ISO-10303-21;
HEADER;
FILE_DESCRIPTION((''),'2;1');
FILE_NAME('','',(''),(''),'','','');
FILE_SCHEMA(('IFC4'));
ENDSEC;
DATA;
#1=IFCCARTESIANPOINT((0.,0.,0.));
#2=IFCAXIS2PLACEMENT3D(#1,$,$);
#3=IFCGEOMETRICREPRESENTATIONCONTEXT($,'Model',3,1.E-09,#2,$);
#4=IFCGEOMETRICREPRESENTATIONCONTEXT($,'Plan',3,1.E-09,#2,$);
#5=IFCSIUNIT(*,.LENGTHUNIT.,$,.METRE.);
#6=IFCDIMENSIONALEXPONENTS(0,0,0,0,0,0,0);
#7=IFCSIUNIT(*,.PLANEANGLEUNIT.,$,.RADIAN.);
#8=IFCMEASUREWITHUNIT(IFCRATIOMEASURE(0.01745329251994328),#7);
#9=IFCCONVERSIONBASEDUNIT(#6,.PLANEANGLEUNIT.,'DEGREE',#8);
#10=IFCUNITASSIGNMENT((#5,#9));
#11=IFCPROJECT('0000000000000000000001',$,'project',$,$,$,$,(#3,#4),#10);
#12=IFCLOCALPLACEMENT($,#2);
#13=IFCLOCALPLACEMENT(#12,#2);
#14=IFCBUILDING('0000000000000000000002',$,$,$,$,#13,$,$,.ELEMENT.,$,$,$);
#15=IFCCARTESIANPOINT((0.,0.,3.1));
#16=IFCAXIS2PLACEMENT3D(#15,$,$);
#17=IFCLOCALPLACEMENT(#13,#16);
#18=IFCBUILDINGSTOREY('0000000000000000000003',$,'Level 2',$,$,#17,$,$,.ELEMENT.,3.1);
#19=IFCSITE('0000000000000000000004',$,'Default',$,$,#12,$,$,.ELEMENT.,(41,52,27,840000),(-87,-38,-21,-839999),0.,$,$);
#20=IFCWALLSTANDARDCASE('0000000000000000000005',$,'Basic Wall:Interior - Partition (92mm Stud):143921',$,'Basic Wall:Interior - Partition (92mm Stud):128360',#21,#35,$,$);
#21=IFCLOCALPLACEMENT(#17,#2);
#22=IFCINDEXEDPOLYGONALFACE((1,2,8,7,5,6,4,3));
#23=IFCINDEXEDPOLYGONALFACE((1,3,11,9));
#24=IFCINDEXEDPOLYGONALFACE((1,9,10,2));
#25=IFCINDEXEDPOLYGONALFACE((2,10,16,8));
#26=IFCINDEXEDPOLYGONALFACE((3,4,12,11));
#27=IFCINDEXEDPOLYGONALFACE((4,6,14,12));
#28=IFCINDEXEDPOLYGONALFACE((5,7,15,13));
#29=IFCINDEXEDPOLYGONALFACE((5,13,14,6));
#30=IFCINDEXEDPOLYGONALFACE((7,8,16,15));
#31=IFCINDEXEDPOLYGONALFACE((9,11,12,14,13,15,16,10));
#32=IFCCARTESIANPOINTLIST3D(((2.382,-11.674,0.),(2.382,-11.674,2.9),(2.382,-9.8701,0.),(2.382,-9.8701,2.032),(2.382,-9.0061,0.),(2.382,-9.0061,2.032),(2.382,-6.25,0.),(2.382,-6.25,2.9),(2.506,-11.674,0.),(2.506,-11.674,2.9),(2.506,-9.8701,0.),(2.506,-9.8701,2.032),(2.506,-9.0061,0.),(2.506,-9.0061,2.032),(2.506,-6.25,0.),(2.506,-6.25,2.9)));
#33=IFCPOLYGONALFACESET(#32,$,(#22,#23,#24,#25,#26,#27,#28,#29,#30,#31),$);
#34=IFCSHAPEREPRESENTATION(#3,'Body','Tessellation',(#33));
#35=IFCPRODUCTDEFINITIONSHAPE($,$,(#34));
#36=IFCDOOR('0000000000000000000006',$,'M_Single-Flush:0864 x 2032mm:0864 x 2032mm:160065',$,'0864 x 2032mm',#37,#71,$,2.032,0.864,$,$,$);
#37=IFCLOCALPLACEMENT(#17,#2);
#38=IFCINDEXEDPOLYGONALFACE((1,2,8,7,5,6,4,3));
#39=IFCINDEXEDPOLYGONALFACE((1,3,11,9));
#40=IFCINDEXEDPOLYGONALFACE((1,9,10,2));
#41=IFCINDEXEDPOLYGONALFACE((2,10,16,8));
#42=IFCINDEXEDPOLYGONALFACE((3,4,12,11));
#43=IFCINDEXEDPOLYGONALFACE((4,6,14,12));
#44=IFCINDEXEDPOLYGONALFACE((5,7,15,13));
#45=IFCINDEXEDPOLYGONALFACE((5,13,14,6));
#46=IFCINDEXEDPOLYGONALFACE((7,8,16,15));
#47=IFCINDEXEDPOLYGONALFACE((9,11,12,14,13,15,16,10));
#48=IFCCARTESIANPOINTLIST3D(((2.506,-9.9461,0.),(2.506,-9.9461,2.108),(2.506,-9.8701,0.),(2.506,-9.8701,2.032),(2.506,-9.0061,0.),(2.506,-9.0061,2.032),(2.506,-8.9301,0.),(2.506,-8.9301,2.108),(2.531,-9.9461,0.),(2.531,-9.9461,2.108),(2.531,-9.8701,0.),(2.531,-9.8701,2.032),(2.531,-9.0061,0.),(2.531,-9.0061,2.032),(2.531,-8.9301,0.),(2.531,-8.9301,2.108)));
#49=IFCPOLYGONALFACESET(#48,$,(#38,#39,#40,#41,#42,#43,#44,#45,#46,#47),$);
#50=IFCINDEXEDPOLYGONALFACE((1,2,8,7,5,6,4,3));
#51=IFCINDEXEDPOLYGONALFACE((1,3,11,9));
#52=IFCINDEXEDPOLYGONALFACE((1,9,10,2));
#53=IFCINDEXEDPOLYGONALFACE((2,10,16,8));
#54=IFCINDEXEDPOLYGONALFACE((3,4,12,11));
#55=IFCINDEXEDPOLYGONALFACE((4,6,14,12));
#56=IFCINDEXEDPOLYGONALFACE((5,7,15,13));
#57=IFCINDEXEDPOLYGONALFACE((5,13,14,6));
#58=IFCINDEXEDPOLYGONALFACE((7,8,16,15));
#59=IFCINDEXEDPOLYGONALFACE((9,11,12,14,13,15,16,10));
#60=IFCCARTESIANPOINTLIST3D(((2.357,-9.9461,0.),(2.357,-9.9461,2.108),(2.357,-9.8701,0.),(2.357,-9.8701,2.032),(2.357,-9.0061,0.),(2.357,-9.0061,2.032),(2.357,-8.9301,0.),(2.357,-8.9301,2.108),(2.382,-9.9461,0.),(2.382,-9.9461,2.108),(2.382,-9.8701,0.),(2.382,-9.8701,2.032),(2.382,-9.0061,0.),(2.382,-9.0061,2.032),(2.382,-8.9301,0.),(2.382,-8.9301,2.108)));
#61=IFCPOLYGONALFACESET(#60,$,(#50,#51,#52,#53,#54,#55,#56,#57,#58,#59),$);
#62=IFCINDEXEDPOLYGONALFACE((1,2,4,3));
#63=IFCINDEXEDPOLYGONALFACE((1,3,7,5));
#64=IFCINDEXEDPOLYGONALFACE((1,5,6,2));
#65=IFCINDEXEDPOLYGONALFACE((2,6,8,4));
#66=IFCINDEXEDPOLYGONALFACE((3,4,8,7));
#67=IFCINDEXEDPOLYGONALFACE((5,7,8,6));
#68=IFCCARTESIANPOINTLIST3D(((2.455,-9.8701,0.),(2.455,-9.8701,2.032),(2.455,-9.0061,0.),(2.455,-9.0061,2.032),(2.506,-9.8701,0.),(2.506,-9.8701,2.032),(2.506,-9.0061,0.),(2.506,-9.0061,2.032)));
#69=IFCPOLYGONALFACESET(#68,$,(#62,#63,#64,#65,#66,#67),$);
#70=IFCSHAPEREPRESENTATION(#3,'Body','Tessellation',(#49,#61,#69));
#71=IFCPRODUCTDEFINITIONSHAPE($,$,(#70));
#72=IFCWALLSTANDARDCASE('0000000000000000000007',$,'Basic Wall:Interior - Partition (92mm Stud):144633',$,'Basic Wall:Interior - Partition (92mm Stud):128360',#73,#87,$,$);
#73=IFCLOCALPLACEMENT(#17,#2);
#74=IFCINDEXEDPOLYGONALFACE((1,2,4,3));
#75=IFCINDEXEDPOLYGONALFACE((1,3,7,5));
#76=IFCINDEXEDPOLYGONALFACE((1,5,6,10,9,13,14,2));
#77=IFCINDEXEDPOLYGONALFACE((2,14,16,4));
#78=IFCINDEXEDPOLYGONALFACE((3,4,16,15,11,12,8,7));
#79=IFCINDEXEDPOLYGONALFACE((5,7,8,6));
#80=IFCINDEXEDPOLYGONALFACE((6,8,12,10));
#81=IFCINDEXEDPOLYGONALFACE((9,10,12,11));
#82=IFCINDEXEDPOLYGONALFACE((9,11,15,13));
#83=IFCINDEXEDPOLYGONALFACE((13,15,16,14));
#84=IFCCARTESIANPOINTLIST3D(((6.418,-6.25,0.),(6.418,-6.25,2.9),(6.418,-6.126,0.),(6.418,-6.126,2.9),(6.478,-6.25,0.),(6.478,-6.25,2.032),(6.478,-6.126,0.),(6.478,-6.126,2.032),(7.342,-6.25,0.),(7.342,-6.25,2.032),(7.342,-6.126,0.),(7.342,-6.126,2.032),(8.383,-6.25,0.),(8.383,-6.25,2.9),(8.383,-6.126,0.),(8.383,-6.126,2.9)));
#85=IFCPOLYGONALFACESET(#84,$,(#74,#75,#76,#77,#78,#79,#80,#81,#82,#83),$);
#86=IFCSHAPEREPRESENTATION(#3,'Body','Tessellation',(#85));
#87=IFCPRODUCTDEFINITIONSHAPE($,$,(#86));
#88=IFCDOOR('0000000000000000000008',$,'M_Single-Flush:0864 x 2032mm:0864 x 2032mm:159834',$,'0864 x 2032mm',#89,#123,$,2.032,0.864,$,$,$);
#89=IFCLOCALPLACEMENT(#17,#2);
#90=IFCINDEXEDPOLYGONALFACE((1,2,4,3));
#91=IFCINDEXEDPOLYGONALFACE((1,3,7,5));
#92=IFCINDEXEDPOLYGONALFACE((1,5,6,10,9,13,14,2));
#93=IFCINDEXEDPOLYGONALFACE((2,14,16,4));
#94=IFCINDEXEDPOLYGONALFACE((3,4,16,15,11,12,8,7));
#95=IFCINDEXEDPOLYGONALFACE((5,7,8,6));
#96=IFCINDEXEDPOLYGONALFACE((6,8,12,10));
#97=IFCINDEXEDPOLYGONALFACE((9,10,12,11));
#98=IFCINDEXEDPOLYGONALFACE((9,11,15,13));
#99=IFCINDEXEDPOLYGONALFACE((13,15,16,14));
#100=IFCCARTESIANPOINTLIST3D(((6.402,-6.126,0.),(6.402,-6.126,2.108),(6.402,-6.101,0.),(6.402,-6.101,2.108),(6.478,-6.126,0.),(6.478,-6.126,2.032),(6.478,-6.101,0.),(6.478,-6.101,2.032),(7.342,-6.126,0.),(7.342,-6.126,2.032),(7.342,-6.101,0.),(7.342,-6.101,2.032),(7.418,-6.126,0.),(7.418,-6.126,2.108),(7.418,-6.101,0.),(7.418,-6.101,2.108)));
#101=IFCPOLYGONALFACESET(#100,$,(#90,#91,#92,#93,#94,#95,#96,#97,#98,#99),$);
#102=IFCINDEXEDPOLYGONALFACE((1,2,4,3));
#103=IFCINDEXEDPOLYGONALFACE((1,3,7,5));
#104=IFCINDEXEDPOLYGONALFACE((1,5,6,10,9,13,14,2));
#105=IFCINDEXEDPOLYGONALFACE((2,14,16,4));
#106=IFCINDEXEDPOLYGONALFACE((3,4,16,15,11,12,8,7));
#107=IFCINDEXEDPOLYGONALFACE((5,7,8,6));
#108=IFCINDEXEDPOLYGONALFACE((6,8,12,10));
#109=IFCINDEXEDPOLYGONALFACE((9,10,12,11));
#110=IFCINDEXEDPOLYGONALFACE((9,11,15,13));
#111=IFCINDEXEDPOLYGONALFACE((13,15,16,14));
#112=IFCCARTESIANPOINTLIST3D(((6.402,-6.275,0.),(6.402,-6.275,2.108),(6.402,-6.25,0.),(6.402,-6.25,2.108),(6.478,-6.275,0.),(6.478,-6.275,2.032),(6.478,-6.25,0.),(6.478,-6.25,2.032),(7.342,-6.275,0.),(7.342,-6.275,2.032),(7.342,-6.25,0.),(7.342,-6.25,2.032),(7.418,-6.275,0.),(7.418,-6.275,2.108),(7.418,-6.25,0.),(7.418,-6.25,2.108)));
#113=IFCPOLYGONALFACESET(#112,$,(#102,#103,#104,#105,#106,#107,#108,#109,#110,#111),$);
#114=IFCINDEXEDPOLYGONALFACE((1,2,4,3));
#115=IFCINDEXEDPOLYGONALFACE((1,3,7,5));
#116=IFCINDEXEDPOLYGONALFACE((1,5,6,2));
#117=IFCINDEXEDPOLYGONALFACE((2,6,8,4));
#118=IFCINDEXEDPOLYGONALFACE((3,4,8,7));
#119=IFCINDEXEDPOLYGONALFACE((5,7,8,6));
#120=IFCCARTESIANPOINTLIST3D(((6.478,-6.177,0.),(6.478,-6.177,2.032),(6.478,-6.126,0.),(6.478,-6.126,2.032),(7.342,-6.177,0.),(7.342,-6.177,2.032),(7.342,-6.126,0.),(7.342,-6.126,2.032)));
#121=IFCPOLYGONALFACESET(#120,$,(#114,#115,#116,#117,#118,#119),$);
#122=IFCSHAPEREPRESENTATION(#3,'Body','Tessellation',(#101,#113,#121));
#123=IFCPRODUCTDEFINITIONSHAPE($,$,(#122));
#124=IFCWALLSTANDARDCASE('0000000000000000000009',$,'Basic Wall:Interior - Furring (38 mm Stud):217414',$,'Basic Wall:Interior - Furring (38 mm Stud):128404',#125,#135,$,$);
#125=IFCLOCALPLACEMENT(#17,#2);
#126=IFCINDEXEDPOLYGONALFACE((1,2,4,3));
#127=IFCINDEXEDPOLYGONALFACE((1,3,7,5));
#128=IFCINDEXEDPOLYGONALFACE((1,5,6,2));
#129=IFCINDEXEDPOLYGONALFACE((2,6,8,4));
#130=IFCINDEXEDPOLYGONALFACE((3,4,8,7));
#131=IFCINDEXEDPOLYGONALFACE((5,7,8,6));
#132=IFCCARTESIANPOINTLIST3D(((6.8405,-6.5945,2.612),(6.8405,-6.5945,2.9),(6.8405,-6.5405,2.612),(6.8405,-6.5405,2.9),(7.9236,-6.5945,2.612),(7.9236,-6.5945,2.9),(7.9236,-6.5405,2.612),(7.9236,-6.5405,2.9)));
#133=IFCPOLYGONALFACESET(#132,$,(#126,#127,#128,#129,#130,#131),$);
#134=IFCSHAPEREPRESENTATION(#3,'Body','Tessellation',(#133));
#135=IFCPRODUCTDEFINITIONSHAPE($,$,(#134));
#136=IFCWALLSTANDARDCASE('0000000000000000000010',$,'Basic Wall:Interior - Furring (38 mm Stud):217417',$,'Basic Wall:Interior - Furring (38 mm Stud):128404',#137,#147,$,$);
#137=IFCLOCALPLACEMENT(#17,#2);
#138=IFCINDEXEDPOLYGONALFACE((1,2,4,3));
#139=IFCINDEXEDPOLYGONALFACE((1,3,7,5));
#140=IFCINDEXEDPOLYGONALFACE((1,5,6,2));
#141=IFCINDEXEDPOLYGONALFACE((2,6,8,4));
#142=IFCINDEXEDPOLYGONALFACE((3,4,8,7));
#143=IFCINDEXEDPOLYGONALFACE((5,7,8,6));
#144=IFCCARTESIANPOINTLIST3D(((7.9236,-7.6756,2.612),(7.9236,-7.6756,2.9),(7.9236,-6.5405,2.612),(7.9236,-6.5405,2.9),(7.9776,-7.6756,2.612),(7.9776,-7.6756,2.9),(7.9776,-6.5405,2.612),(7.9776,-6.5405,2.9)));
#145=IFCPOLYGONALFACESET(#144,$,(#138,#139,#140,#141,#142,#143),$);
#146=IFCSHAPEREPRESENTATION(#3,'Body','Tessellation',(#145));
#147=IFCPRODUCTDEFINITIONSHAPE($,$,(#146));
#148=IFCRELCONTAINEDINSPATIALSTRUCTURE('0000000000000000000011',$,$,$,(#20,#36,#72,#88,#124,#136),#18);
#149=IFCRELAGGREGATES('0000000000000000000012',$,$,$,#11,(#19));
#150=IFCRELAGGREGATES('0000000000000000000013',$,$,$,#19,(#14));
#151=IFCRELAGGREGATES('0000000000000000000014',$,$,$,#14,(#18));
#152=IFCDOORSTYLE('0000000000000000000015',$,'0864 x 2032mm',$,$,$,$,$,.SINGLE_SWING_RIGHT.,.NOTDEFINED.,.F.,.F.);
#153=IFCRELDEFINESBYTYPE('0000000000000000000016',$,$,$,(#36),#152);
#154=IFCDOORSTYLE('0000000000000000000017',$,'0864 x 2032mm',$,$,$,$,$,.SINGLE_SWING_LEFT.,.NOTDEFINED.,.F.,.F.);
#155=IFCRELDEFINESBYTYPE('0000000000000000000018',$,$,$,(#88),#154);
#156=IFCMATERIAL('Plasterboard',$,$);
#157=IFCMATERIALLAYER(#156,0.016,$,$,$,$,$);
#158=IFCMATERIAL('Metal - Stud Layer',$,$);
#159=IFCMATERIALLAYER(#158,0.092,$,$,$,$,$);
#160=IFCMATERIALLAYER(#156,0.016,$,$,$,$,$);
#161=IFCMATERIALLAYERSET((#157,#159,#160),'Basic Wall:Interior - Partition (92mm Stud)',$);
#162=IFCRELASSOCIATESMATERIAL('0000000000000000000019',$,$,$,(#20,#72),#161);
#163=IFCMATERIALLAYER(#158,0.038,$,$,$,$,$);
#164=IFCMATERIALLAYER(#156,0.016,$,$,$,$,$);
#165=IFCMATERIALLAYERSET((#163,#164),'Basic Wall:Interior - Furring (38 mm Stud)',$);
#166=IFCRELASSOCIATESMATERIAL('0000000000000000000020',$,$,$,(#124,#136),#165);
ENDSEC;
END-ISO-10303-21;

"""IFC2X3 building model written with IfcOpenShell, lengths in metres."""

from ifc_helpers import new_model, entity, si_unit, converted_unit, frame, frame_2d, origin, origin_2d_with_axis, place, context, project, spatial, polyline, rectangle, outline, extrude, source, transform, mapped, material, layer, layer_set, layer_usage, type_object, type_shapes, element, fill, save


model = new_model("IFC2X3")

# Units and contexts
model_context = context("Model", 3, precision=1e-09, world=origin())
plan_context = context("Plan", 3, precision=1e-09, world=origin())
ifc_project = project(units=[si_unit("LENGTHUNIT", "METRE"), converted_unit("PLANEANGLEUNIT", "DEGREE", entity("IfcRatioMeasure", 0.01745329251994328), si_unit("PLANEANGLEUNIT", "RADIAN"), dimensions=[0, 0, 0, 0, 0, 0, 0])], contexts=[model_context, plan_context])

# Site, building, storey
site_placement = place(None, origin())
site = spatial("IfcSite", under=ifc_project, at=site_placement, Name="Default", CompositionType="ELEMENT", RefLatitude=(41, 52, 27, 840000), RefLongitude=(-87, -38, -21, -839999), RefElevation=0.0)
building_placement = place(site_placement, origin())
building = spatial("IfcBuilding", under=site, at=building_placement, CompositionType="ELEMENT")
storey_placement = place(building_placement, frame((0.0, 0.0, 3.1)))
storey = spatial("IfcBuildingStorey", under=building, at=storey_placement, Name="Level 2", CompositionType="ELEMENT", Elevation=3.1)

# Wall, opening, door
ifc_material_1 = material(Name="Plasterboard")
ifc_layer_1 = layer(ifc_material_1, 0.016)
ifc_material_2 = material(Name="Metal - Stud Layer")
ifc_layer_2 = layer(ifc_material_2, 0.092)
ifc_layer_3 = layer(ifc_material_1, 0.016)
ifc_layer_set_1 = layer_set([ifc_layer_1, ifc_layer_2, ifc_layer_3], Name="Basic Wall:Interior - Partition (92mm Stud)")
ifc_layer_usage_1 = layer_usage(ifc_layer_set_1, "AXIS2", "NEGATIVE", 0.062)
wall_1_placement = place(storey_placement, frame((2.444, -6.25, 0.0), z_axis=(0.0, 0.0, 1.0), x_axis=(0.0, -1.0, 0.0)))
wall_1 = element("IfcWallStandardCase", 1, at=wall_1_placement, inside=storey, material=ifc_layer_usage_1, Name="Basic Wall:Interior - Partition (92mm Stud):143921", ObjectType="Basic Wall:Interior - Partition (92mm Stud):128360", context=model_context, shape_type="SweptSolid", body=[
    extrude(rectangle(XDim=5.424, YDim=0.124, at=frame_2d((2.712, 0.0), x_axis=(-1.0, 0.0))), origin(), (0.0, 0.0, 1.0), 2.9),
])
opening_1_placement = place(wall_1_placement, frame((2.7561, -0.062, 0.0)))
opening_1 = element("IfcOpeningElement", 2, at=opening_1_placement, cuts=wall_1, ObjectType="Opening", context=model_context, shape_type="SweptSolid", body=[
    extrude(rectangle(XDim=0.864, YDim=2.032, at=frame_2d((1.016, 0.432), x_axis=(0.0, 1.0))), frame((0.0, 0.0, 0.0), z_axis=(0.0, 1.0, 0.0), x_axis=(0.0, 0.0, 1.0)), (0.0, 0.0, 1.0), 0.124),
])
door_style_1 = type_object("IfcDoorStyle", Name="0864 x 2032mm", ConstructionType="NOTDEFINED", OperationType="SINGLE_SWING_RIGHT", ParameterTakesPrecedence=False, Sizeable=False)
shared_shape_1 = source(origin(), model_context, "Body", "SweptSolid", [
    extrude(outline(polyline([(-0.508, -1.073), (0.508, -1.073), (0.508, 1.035), (0.432, 1.035), (0.432, -0.997), (-0.432, -0.997), (-0.432, 1.035), (-0.508, 1.035), (-0.508, -1.073)])), frame((0.432, 0.124, 1.035), z_axis=(0.0, 1.0, 0.0), x_axis=(1.0, 0.0, 0.0)), (0.0, 0.0, 1.0), 0.025),
    extrude(outline(polyline([(-1.073, -0.508), (1.035, -0.508), (1.035, -0.432), (-0.997, -0.432), (-0.997, 0.432), (1.035, 0.432), (1.035, 0.508), (-1.073, 0.508), (-1.073, -0.508)])), frame((0.432, -0.025, 1.035), z_axis=(0.0, 1.0, 0.0), x_axis=(0.0, 0.0, -1.0)), (0.0, 0.0, 1.0), 0.025),
    extrude(rectangle(XDim=0.051, YDim=0.864, at=origin_2d_with_axis()), frame((0.432, 0.0985, 0.0), z_axis=(0.0, 0.0, 1.0), x_axis=(0.0, 1.0, 0.0)), (0.0, 0.0, 1.0), 2.032),
])
type_shapes(door_style_1, [shared_shape_1])
door_1_placement = place(opening_1_placement, origin())
door_1 = element("IfcDoor", 3, at=door_1_placement, inside=storey, type_object=door_style_1, Name="M_Single-Flush:0864 x 2032mm:0864 x 2032mm:160065", ObjectType="0864 x 2032mm", OverallHeight=2.032, OverallWidth=0.864, context=model_context, shape_type="MappedRepresentation", body=[
    mapped(shared_shape_1, transform((0.0, 0.0, 0.0), scale=1.0)),
])
fill(opening_1, door_1)

# Wall, opening, door
wall_2_placement = place(storey_placement, frame((6.418, -6.188, 0.0)))
wall_2 = element("IfcWallStandardCase", 4, at=wall_2_placement, inside=storey, material=ifc_layer_usage_1, Name="Basic Wall:Interior - Partition (92mm Stud):144633", ObjectType="Basic Wall:Interior - Partition (92mm Stud):128360", context=model_context, shape_type="SweptSolid", body=[
    extrude(rectangle(XDim=1.965, YDim=0.124, at=frame_2d((0.9825, 0.0), x_axis=(-1.0, 0.0))), origin(), (0.0, 0.0, 1.0), 2.9),
])
opening_2_placement = place(wall_2_placement, frame((0.06, -0.062, 0.0)))
opening_2 = element("IfcOpeningElement", 5, at=opening_2_placement, cuts=wall_2, ObjectType="Opening", context=model_context, shape_type="SweptSolid", body=[
    extrude(rectangle(XDim=0.864, YDim=2.032, at=frame_2d((1.016, 0.432), x_axis=(0.0, -1.0))), frame((0.0, 0.0, 0.0), z_axis=(0.0, 1.0, 0.0), x_axis=(0.0, 0.0, 1.0)), (0.0, 0.0, 1.0), 0.124),
])
door_style_2 = type_object("IfcDoorStyle", Name="0864 x 2032mm", ConstructionType="NOTDEFINED", OperationType="SINGLE_SWING_LEFT", ParameterTakesPrecedence=False, Sizeable=False)
shared_shape_2 = source(origin(), model_context, "Body", "SweptSolid", [
    extrude(outline(polyline([(-0.508, -1.073), (0.508, -1.073), (0.508, 1.035), (0.432, 1.035), (0.432, -0.997), (-0.432, -0.997), (-0.432, 1.035), (-0.508, 1.035), (-0.508, -1.073)])), frame((0.432, 0.149, 1.035), z_axis=(0.0, -1.0, 0.0), x_axis=(-1.0, 0.0, 0.0)), (0.0, 0.0, 1.0), 0.025),
    extrude(outline(polyline([(-1.073, -0.508), (1.035, -0.508), (1.035, -0.432), (-0.997, -0.432), (-0.997, 0.432), (1.035, 0.432), (1.035, 0.508), (-1.073, 0.508), (-1.073, -0.508)])), frame((0.432, 0.0, 1.035), z_axis=(0.0, -1.0, 0.0), x_axis=(0.0, 0.0, -1.0)), (0.0, 0.0, 1.0), 0.025),
    extrude(rectangle(XDim=0.864, YDim=0.051, at=origin_2d_with_axis()), frame((0.432, 0.0985, 0.0)), (0.0, 0.0, 1.0), 2.032),
])
type_shapes(door_style_2, [shared_shape_2])
door_2_placement = place(opening_2_placement, origin())
door_2 = element("IfcDoor", 6, at=door_2_placement, inside=storey, type_object=door_style_2, Name="M_Single-Flush:0864 x 2032mm:0864 x 2032mm:159834", ObjectType="0864 x 2032mm", OverallHeight=2.032, OverallWidth=0.864, context=model_context, shape_type="MappedRepresentation", body=[
    mapped(shared_shape_2, transform((0.0, 0.0, 0.0), scale=1.0)),
])
fill(opening_2, door_2)

# Walls
ifc_layer_4 = layer(ifc_material_2, 0.038)
ifc_layer_5 = layer(ifc_material_1, 0.016)
ifc_layer_set_2 = layer_set([ifc_layer_4, ifc_layer_5], Name="Basic Wall:Interior - Furring (38 mm Stud)")
ifc_layer_usage_2 = layer_usage(ifc_layer_set_2, "AXIS2", "NEGATIVE", 0.027)
wall_3_placement = place(storey_placement, frame((6.8405, -6.5675, 2.612)))
element("IfcWallStandardCase", 7, at=wall_3_placement, inside=storey, material=ifc_layer_usage_2, Name="Basic Wall:Interior - Furring (38 mm Stud):217414", ObjectType="Basic Wall:Interior - Furring (38 mm Stud):128404", context=model_context, shape_type="SweptSolid", body=[
    extrude(rectangle(XDim=1.0831, YDim=0.054, at=frame_2d((0.5416, 0.0), x_axis=(-1.0, 0.0))), origin(), (0.0, 0.0, 1.0), 0.288),
])
wall_4_placement = place(storey_placement, frame((7.9506, -6.5405, 2.612), z_axis=(0.0, 0.0, 1.0), x_axis=(0.0, -1.0, 0.0)))
element("IfcWallStandardCase", 8, at=wall_4_placement, inside=storey, material=ifc_layer_usage_2, Name="Basic Wall:Interior - Furring (38 mm Stud):217417", ObjectType="Basic Wall:Interior - Furring (38 mm Stud):128404", context=model_context, shape_type="SweptSolid", body=[
    extrude(rectangle(XDim=1.1351, YDim=0.054, at=frame_2d((0.5675, 0.0), x_axis=(-1.0, 0.0))), origin(), (0.0, 0.0, 1.0), 0.288),
])

save(model, "model.ifc")
